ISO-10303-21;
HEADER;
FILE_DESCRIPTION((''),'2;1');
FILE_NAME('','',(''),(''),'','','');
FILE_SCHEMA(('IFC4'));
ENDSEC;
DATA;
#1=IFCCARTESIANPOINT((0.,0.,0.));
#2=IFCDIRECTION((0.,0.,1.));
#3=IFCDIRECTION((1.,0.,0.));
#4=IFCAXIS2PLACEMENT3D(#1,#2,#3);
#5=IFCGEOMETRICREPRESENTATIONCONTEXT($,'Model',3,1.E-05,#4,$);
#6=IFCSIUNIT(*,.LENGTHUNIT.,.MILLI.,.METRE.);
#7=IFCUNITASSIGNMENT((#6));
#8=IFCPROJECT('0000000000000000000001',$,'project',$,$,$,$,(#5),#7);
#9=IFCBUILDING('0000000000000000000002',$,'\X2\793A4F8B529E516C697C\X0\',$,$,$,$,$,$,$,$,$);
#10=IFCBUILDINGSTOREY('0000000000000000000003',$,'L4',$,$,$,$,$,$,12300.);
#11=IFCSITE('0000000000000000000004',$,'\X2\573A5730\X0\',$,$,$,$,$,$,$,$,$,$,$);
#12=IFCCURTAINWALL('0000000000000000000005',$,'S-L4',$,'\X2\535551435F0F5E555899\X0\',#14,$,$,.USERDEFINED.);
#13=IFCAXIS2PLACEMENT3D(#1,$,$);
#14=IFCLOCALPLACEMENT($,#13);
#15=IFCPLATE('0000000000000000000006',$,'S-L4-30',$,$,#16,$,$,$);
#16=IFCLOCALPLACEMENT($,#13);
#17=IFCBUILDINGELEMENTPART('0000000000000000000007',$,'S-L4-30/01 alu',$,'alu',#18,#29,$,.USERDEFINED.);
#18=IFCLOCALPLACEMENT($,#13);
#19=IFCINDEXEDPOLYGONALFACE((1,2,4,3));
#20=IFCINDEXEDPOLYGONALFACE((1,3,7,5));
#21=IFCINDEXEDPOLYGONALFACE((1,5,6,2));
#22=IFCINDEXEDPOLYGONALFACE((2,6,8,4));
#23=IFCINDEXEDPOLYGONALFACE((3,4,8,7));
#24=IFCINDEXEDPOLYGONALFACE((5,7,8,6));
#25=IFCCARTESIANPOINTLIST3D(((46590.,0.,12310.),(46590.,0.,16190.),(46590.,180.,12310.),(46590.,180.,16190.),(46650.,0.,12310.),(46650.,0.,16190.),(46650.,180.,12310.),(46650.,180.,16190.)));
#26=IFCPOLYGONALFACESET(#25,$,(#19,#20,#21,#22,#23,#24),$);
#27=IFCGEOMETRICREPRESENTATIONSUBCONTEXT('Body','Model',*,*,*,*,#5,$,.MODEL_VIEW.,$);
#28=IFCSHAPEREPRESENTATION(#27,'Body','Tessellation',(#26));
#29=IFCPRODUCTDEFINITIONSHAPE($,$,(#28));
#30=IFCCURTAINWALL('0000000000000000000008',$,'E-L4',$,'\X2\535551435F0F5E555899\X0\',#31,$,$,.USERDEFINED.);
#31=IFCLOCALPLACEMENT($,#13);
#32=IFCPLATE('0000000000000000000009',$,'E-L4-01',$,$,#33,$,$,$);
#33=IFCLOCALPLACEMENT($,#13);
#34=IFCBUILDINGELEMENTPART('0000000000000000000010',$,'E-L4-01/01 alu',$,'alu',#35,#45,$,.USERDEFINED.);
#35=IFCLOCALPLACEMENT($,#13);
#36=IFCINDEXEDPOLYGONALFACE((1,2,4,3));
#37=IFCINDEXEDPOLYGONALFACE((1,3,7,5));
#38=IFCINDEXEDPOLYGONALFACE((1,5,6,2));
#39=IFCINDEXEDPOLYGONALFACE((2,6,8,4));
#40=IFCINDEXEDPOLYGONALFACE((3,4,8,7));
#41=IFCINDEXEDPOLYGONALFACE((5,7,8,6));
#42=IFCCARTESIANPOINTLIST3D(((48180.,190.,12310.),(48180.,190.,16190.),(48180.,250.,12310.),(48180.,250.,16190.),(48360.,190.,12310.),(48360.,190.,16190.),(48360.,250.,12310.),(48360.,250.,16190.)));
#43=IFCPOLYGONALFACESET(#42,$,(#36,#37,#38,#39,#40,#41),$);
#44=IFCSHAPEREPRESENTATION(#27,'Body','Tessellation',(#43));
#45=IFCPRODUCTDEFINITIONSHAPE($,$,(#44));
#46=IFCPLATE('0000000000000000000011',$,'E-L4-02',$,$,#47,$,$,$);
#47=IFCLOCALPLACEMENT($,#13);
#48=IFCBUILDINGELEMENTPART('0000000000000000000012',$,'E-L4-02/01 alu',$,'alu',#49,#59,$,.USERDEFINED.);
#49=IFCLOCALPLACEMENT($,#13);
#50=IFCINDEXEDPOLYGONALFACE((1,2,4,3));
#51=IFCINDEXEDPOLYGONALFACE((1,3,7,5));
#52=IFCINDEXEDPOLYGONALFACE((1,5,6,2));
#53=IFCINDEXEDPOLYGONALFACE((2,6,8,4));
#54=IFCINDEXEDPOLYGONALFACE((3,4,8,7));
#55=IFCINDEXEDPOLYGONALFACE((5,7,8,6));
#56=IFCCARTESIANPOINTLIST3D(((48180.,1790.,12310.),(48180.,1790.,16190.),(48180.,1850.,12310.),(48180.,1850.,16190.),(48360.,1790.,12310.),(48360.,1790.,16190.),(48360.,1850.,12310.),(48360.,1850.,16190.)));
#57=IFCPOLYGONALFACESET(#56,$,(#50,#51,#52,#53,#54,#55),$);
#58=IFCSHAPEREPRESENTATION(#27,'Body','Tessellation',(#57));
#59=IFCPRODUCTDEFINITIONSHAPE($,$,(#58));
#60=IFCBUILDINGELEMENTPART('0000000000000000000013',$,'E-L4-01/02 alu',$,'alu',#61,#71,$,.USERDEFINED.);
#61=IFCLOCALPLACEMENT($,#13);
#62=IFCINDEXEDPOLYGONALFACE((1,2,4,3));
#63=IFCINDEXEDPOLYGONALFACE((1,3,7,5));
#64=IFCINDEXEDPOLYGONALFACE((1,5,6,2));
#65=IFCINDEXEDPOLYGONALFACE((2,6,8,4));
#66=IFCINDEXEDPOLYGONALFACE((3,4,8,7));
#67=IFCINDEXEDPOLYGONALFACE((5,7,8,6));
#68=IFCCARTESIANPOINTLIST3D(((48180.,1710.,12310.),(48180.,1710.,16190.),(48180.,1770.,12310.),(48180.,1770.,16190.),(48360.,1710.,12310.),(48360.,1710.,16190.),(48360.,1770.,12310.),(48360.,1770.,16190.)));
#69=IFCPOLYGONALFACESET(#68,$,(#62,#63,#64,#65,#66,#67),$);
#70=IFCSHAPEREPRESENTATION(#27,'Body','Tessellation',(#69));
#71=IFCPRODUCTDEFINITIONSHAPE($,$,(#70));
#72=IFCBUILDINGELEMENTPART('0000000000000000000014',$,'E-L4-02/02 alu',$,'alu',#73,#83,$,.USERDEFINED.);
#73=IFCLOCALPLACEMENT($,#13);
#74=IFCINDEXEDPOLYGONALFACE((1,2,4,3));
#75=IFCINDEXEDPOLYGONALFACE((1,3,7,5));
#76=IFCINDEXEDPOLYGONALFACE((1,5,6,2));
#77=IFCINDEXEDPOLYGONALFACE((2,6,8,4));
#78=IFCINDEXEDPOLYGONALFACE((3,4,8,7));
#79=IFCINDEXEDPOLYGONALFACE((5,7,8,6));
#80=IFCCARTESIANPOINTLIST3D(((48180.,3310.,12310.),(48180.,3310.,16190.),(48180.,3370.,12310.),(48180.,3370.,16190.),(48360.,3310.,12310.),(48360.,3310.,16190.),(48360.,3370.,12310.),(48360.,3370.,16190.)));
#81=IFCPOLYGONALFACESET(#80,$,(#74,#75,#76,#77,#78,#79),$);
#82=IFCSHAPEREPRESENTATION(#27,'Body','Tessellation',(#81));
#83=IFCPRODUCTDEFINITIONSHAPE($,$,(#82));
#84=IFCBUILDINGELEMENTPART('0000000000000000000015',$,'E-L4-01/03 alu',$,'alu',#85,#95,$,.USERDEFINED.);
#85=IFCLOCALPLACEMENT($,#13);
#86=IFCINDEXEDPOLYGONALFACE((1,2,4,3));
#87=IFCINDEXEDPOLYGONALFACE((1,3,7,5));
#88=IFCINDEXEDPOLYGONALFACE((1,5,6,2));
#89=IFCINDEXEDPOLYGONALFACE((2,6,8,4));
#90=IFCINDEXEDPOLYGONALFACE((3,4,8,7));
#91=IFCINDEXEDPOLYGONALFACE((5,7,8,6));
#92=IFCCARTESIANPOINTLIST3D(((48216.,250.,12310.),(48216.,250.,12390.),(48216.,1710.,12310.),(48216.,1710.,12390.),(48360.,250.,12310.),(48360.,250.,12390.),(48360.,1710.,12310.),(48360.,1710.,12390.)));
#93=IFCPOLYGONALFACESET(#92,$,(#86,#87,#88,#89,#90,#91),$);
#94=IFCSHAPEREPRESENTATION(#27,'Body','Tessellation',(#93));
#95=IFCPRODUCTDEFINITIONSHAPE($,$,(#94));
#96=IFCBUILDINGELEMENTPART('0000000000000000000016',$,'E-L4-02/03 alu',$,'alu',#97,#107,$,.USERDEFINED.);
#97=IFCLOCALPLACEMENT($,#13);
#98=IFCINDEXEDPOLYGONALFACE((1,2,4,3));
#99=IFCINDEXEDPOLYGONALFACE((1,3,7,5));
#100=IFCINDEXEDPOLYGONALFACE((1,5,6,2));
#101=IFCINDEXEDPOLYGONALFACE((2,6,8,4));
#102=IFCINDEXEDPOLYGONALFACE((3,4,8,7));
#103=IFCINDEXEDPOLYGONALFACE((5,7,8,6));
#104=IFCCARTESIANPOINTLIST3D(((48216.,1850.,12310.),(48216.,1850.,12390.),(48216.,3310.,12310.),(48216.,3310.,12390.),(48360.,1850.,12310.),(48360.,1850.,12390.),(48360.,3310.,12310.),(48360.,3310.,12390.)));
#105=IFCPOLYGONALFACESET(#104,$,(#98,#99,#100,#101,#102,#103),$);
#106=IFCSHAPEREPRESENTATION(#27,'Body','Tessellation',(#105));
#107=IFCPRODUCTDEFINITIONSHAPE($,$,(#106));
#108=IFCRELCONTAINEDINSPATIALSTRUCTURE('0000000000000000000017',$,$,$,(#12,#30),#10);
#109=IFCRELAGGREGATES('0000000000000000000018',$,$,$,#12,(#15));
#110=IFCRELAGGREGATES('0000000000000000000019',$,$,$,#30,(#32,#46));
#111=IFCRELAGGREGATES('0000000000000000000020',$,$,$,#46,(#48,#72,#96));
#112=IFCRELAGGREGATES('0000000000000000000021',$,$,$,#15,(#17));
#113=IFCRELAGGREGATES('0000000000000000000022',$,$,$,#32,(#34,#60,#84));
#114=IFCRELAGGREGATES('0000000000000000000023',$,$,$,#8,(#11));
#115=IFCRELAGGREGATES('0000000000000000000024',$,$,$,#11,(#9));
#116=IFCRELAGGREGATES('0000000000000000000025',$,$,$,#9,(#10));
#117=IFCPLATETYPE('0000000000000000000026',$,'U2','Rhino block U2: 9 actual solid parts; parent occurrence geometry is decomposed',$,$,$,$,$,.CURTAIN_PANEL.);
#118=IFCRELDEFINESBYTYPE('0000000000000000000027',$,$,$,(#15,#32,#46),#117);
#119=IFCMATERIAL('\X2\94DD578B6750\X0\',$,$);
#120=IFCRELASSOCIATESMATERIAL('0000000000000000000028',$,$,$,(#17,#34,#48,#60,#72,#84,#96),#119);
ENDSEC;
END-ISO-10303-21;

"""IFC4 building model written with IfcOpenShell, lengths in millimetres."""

from ifc_helpers import new_model, si_unit, frame, frame_2d, origin, origin_with_axes, place, context, subcontext, project, spatial, rectangle, extrude, source, transform, mapped, material, type_object, element, aggregate, save


model = new_model("IFC4")

# Units and contexts
model_context = context("Model", 3, precision=1e-05, world=origin_with_axes())
body_context = subcontext(model_context, "Body", "Model", "MODEL_VIEW")
ifc_project = project(units=[si_unit("LENGTHUNIT", "METRE", prefix="MILLI")], contexts=[model_context])

# Site, building, storey
site = spatial("IfcSite", under=ifc_project, Name="场地")
building = spatial("IfcBuilding", under=site, Name="示例办公楼")
storey = spatial("IfcBuildingStorey", under=building, Name="L4", Elevation=12300.0)

# Curtain wall, plate, building element part
curtain_wall_1 = element("IfcCurtainWall", 1, inside=storey, Name="S-L4", ObjectType="单元式幕墙", PredefinedType="USERDEFINED")
plate_type = type_object("IfcPlateType", Name="U2", Description="Rhino block U2: 9 actual solid parts; parent occurrence geometry is decomposed", PredefinedType="CURTAIN_PANEL")
plate_1_placement = place(None, frame((46590.0, 0.0, 12310.0), z_axis=(0.0, 0.0, 1.0), x_axis=(1.0, 0.0, 0.0)))
plate_1 = element("IfcPlate", 2, at=plate_1_placement, type_object=plate_type, Name="S-L4-30")
aggregate(curtain_wall_1, [plate_1])
ifc_material_1 = material(Name="铝型材")
shared_shape_1 = source(origin(), body_context, "Body", "SweptSolid", [
    extrude(rectangle(XDim=60.0, YDim=180.0, at=frame_2d((30.0, 90.0))), origin(), (0.0, 0.0, 1.0), 3880.0),
])
building_element_part_1_placement = place(plate_1_placement, origin())
building_element_part_1 = element("IfcBuildingElementPart", 3, at=building_element_part_1_placement, material=ifc_material_1, Name="S-L4-30/01 alu", ObjectType="alu", PredefinedType="USERDEFINED", context=body_context, shape_type="MappedRepresentation", body=[
    mapped(shared_shape_1, transform((0.0, 0.0, 0.0))),
])

# Curtain wall, plates, building element parts
curtain_wall_2 = element("IfcCurtainWall", 4, inside=storey, Name="E-L4", ObjectType="单元式幕墙", PredefinedType="USERDEFINED")
plate_2_placement = place(None, frame((48360.0, 190.0, 12310.0), z_axis=(0.0, 0.0, 1.0), x_axis=(0.0, 1.0, 0.0)))
plate_2 = element("IfcPlate", 5, at=plate_2_placement, type_object=plate_type, Name="E-L4-01")
building_element_part_2_placement = place(plate_2_placement, origin())
building_element_part_2 = element("IfcBuildingElementPart", 6, at=building_element_part_2_placement, material=ifc_material_1, Name="E-L4-01/01 alu", ObjectType="alu", PredefinedType="USERDEFINED", context=body_context, shape_type="MappedRepresentation", body=[
    mapped(shared_shape_1, transform((0.0, 0.0, 0.0))),
])
plate_3_placement = place(None, frame((48360.0, 1790.0, 12310.0), z_axis=(0.0, 0.0, 1.0), x_axis=(0.0, 1.0, 0.0)))
plate_3 = element("IfcPlate", 7, at=plate_3_placement, type_object=plate_type, Name="E-L4-02")
aggregate(curtain_wall_2, [plate_2, plate_3])
building_element_part_3_placement = place(plate_3_placement, origin())
building_element_part_3 = element("IfcBuildingElementPart", 8, at=building_element_part_3_placement, material=ifc_material_1, Name="E-L4-02/01 alu", ObjectType="alu", PredefinedType="USERDEFINED", context=body_context, shape_type="MappedRepresentation", body=[
    mapped(shared_shape_1, transform((0.0, 0.0, 0.0))),
])

# Building element parts
shared_shape_2 = source(origin(), body_context, "Body", "SweptSolid", [
    extrude(rectangle(XDim=60.0, YDim=180.0, at=frame_2d((1550.0, 90.0))), origin(), (0.0, 0.0, 1.0), 3880.0),
])
building_element_part_4_placement = place(plate_2_placement, origin())
building_element_part_4 = element("IfcBuildingElementPart", 9, at=building_element_part_4_placement, material=ifc_material_1, Name="E-L4-01/02 alu", ObjectType="alu", PredefinedType="USERDEFINED", context=body_context, shape_type="MappedRepresentation", body=[
    mapped(shared_shape_2, transform((0.0, 0.0, 0.0))),
])
building_element_part_5_placement = place(plate_3_placement, origin())
building_element_part_5 = element("IfcBuildingElementPart", 10, at=building_element_part_5_placement, material=ifc_material_1, Name="E-L4-02/02 alu", ObjectType="alu", PredefinedType="USERDEFINED", context=body_context, shape_type="MappedRepresentation", body=[
    mapped(shared_shape_2, transform((0.0, 0.0, 0.0))),
])
shared_shape_3 = source(origin(), body_context, "Body", "SweptSolid", [
    extrude(rectangle(XDim=1460.0, YDim=144.0, at=frame_2d((790.0, 72.0))), origin(), (0.0, 0.0, 1.0), 80.0),
])
building_element_part_6_placement = place(plate_2_placement, origin())
building_element_part_6 = element("IfcBuildingElementPart", 11, at=building_element_part_6_placement, material=ifc_material_1, Name="E-L4-01/03 alu", ObjectType="alu", PredefinedType="USERDEFINED", context=body_context, shape_type="MappedRepresentation", body=[
    mapped(shared_shape_3, transform((0.0, 0.0, 0.0))),
])
building_element_part_7_placement = place(plate_3_placement, origin())
building_element_part_7 = element("IfcBuildingElementPart", 12, at=building_element_part_7_placement, material=ifc_material_1, Name="E-L4-02/03 alu", ObjectType="alu", PredefinedType="USERDEFINED", context=body_context, shape_type="MappedRepresentation", body=[
    mapped(shared_shape_3, transform((0.0, 0.0, 0.0))),
])
aggregate(plate_3, [building_element_part_3, building_element_part_5, building_element_part_7])
aggregate(plate_1, [building_element_part_1])
aggregate(plate_2, [building_element_part_2, building_element_part_4, building_element_part_6])

save(model, "model.ifc")
